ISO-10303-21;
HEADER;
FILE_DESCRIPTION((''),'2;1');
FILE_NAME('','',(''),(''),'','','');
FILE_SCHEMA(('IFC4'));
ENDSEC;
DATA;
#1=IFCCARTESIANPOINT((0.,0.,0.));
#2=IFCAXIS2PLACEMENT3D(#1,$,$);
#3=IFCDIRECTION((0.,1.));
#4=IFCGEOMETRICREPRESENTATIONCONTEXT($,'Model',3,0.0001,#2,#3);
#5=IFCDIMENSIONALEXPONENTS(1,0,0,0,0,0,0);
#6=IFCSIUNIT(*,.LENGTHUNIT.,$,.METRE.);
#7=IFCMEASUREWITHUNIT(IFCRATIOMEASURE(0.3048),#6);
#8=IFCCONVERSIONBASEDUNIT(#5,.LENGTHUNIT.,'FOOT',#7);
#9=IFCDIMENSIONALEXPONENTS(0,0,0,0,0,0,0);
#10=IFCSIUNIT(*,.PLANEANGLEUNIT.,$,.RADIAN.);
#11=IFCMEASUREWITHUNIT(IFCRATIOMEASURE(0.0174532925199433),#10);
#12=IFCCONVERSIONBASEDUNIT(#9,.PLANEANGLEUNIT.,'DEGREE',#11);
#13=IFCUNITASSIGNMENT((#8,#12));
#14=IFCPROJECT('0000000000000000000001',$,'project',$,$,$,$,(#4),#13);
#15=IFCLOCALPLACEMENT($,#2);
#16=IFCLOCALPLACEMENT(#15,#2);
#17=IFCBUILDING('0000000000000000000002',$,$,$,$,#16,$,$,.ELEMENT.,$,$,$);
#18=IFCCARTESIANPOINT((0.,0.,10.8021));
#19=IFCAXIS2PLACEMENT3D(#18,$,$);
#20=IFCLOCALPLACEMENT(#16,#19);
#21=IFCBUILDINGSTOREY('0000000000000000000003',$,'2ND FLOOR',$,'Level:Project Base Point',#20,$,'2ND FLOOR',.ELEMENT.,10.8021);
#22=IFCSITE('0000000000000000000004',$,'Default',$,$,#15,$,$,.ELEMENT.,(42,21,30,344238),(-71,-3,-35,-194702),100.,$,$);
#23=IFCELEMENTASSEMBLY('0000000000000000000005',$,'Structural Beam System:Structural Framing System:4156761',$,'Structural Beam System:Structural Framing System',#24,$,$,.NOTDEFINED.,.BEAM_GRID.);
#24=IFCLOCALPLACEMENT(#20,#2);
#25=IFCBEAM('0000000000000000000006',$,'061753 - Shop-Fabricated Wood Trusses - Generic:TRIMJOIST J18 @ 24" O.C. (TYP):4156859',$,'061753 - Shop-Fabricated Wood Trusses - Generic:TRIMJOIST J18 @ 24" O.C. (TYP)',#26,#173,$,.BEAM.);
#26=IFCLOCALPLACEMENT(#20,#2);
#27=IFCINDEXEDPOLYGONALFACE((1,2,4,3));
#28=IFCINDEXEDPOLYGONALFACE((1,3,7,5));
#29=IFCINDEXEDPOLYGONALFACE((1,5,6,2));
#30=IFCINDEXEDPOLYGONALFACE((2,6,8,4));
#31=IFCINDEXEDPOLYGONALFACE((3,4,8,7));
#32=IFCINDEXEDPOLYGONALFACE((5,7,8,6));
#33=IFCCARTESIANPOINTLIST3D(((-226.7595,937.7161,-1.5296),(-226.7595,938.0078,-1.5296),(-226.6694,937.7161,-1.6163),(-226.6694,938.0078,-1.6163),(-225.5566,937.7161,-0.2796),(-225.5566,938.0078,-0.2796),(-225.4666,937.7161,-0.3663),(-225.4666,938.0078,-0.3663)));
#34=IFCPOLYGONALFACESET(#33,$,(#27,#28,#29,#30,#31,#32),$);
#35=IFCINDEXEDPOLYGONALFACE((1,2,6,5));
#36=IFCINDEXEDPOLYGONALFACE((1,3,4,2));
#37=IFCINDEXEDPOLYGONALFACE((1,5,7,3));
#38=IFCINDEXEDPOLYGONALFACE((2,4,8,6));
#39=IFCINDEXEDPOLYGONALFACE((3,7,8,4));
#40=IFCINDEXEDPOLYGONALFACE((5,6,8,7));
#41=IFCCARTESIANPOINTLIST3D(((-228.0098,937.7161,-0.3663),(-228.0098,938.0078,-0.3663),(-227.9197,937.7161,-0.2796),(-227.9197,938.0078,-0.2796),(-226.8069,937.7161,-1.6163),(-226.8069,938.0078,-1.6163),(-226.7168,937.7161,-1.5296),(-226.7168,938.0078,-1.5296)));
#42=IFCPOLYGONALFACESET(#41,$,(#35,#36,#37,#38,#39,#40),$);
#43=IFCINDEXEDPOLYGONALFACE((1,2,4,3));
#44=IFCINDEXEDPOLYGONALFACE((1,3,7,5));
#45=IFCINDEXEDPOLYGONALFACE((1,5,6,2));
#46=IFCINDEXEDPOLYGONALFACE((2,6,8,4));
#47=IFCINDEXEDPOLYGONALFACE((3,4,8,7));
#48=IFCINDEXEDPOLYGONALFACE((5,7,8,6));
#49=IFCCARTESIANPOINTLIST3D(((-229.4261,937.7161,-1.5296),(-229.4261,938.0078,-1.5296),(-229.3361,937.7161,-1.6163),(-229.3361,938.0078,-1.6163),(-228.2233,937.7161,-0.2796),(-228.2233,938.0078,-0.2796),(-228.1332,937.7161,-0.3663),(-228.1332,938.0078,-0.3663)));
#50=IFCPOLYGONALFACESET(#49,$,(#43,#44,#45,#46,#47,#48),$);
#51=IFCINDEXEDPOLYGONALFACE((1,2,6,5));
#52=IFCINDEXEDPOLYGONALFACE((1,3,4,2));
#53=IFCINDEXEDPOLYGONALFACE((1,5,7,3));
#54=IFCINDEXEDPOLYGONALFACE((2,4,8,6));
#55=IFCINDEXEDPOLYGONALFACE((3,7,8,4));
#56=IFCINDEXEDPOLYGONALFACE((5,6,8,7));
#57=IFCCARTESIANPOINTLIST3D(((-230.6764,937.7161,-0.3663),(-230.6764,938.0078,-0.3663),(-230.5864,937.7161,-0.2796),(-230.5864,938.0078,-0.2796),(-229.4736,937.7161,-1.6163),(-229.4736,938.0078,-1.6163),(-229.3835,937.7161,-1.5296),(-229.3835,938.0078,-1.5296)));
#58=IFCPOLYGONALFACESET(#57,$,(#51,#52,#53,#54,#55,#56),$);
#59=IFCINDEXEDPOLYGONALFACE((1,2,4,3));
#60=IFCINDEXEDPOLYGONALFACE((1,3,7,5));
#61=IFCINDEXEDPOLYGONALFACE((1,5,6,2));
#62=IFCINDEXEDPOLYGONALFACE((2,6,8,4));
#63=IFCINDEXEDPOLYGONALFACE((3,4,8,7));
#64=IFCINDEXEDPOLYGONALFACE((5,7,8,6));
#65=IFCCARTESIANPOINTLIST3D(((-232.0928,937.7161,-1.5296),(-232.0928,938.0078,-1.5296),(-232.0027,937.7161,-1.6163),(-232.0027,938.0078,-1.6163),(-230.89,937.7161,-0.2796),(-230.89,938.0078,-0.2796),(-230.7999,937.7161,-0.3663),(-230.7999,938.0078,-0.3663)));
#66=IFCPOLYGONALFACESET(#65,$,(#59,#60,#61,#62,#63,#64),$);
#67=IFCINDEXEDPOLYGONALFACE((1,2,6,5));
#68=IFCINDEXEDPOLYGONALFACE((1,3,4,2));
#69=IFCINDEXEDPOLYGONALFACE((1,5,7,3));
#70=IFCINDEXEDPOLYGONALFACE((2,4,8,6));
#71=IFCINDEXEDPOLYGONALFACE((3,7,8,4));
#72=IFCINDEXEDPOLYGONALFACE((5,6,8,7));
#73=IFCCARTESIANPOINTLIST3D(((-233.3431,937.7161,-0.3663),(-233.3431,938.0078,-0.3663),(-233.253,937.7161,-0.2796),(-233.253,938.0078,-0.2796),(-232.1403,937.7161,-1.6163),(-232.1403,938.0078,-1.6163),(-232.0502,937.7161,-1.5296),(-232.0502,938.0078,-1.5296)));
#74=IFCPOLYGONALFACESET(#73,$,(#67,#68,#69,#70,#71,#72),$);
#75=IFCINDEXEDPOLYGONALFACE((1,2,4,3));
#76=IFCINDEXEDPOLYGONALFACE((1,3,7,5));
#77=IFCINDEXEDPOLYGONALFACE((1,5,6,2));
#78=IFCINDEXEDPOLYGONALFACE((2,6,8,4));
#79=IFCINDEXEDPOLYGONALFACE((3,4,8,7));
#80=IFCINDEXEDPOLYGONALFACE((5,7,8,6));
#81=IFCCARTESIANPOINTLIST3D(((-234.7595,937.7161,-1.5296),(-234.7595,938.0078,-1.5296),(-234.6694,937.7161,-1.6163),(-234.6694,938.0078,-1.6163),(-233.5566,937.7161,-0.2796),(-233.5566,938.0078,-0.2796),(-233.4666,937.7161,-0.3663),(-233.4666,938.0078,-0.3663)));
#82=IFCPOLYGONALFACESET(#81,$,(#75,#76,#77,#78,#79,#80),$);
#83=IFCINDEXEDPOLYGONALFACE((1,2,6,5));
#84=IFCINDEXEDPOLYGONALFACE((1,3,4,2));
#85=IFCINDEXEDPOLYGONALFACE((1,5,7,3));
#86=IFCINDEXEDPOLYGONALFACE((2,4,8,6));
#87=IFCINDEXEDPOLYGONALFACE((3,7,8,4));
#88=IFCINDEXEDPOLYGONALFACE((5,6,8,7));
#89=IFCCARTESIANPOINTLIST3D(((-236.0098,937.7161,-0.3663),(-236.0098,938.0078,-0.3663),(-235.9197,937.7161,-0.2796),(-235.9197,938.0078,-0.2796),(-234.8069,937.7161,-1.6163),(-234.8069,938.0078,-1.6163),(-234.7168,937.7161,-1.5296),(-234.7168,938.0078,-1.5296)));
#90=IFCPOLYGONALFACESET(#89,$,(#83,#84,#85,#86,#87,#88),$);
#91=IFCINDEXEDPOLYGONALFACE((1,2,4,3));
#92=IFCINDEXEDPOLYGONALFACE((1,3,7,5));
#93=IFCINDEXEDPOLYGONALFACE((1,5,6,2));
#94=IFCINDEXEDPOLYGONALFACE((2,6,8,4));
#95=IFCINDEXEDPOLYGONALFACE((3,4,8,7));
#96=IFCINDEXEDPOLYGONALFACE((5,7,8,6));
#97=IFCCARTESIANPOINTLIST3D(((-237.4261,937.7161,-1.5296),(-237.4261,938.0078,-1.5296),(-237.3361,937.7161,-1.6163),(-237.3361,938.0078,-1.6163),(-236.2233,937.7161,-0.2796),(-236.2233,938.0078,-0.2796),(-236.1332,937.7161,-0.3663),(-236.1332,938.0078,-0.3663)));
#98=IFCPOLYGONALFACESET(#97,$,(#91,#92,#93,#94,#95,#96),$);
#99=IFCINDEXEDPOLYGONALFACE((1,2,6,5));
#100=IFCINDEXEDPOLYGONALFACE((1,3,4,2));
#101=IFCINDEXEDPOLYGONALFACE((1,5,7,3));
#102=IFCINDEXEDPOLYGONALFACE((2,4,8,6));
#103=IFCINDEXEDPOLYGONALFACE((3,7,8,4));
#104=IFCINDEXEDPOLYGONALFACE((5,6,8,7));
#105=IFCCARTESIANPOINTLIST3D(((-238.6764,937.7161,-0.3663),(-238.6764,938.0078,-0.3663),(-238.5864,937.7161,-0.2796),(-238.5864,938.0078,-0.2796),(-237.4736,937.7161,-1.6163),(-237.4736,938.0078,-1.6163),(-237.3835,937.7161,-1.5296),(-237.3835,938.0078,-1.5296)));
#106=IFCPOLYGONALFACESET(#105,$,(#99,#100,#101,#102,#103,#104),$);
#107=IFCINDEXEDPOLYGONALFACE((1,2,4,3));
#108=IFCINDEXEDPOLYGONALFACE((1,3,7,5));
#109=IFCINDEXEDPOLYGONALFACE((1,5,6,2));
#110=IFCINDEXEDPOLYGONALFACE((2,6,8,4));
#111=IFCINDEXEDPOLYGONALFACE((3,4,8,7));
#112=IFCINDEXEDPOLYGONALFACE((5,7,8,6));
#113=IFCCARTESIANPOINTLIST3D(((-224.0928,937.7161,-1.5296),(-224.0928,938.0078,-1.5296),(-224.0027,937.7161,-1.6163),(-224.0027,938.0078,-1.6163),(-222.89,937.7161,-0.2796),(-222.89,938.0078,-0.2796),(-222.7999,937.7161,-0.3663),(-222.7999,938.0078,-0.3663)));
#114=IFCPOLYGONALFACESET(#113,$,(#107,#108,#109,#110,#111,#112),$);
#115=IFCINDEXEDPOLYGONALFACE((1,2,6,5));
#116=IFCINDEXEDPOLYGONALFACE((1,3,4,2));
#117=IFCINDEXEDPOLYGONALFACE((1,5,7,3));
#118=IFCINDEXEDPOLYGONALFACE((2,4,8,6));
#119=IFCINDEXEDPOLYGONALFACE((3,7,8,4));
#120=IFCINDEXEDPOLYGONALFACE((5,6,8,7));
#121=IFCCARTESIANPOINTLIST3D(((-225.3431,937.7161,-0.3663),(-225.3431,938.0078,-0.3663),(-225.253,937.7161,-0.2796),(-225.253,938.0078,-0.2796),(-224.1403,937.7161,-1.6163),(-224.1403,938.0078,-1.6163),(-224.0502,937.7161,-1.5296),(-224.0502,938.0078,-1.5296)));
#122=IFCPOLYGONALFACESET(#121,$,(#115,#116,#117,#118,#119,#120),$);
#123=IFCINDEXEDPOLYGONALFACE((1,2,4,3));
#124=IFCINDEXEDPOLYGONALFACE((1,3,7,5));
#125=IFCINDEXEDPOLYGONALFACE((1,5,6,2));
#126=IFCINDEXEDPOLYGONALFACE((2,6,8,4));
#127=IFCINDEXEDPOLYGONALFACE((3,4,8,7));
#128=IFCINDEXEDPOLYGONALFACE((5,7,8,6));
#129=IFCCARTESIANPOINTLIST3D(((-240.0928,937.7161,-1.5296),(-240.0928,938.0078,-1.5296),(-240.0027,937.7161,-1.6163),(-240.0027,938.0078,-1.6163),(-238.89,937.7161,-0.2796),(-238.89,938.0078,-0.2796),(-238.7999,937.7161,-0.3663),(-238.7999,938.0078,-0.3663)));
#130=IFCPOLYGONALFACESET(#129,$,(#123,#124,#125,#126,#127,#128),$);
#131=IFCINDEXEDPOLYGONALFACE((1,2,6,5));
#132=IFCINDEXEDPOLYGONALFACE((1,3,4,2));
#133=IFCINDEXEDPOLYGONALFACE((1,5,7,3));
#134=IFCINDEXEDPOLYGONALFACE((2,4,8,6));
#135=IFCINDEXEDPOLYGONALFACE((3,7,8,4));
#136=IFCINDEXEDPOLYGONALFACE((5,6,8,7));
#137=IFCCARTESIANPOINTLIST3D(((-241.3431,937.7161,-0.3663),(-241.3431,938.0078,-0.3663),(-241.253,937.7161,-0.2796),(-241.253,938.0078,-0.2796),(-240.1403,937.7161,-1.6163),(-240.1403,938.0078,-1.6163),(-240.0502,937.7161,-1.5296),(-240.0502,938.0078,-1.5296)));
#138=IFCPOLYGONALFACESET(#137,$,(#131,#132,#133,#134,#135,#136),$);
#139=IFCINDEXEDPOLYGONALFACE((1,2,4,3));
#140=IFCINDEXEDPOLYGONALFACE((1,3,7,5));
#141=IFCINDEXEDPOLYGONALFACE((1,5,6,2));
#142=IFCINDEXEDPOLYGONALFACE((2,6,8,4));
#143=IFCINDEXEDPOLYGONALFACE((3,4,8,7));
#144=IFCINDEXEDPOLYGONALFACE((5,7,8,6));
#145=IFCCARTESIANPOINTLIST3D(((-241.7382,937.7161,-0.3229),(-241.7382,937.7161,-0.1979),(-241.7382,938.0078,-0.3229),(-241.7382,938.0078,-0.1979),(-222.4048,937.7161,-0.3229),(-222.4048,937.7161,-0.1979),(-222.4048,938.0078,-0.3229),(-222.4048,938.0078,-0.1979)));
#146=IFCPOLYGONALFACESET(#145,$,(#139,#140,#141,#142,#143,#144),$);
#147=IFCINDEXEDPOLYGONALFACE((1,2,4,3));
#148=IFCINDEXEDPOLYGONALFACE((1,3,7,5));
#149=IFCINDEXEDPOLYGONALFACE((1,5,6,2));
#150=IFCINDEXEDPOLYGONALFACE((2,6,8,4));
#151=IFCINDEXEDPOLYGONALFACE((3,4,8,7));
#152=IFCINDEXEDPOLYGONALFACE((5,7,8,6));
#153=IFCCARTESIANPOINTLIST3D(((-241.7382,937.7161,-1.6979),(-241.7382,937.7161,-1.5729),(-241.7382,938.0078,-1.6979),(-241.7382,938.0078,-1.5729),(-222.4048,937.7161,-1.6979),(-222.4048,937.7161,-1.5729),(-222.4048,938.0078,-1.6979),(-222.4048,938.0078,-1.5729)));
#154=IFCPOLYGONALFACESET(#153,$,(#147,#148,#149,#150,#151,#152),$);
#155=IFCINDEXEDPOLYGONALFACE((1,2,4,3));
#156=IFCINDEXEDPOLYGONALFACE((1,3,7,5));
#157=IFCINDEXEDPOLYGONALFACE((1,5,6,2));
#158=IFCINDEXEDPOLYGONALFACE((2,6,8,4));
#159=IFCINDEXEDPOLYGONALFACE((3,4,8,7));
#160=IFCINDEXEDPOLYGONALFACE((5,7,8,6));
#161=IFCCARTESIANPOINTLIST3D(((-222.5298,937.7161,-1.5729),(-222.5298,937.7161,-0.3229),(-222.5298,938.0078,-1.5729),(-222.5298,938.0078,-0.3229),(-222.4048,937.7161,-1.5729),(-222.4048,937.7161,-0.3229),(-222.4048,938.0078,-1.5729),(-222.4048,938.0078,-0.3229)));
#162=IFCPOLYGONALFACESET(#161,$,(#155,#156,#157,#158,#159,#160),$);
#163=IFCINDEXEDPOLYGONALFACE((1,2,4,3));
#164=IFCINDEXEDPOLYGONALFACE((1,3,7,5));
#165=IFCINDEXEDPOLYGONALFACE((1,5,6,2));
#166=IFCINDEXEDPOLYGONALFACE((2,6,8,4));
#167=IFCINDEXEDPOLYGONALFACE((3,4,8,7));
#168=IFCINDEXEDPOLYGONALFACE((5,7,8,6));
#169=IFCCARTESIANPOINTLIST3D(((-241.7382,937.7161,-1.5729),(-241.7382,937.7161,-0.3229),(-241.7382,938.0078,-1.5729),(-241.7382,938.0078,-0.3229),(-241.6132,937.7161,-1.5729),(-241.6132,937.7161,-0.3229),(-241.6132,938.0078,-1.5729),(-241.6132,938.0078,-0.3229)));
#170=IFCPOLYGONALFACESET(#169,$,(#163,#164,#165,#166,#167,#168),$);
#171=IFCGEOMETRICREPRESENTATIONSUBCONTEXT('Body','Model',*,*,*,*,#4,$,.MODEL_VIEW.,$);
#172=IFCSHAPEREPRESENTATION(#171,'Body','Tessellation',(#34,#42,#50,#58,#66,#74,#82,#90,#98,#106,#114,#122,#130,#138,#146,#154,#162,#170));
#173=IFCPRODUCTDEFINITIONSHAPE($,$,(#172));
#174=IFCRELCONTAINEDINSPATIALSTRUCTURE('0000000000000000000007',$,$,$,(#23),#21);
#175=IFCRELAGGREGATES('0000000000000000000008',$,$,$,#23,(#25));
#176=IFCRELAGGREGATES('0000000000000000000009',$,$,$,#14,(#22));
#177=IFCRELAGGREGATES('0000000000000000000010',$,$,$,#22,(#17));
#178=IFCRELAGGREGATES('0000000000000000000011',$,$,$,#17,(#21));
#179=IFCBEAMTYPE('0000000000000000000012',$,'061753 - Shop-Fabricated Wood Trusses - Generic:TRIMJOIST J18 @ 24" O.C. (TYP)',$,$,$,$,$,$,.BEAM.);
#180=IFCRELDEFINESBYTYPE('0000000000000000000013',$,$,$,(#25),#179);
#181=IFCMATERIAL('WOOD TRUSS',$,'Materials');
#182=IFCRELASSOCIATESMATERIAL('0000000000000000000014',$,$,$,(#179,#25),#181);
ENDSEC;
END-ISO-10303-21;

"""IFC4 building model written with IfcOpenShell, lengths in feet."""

from ifc_helpers import new_model, entity, si_unit, converted_unit, direction, frame, frame_2d, origin, origin_2d_with_axis, place, context, subcontext, project, spatial, rectangle, extrude, source, transform, mapped, material, material_profile, profile_set, profile_usage, type_object, type_shapes, element, aggregate, save


model = new_model("IFC4")

# Units and contexts
model_context = context("Model", 3, precision=0.0001, world=origin(), true_north=direction((0.0, 1.0)))
body_context = subcontext(model_context, "Body", "Model", "MODEL_VIEW")
ifc_project = project(units=[converted_unit("LENGTHUNIT", "FOOT", entity("IfcRatioMeasure", 0.3048), si_unit("LENGTHUNIT", "METRE"), dimensions=[1, 0, 0, 0, 0, 0, 0]), converted_unit("PLANEANGLEUNIT", "DEGREE", entity("IfcRatioMeasure", 0.0174532925199433), si_unit("PLANEANGLEUNIT", "RADIAN"), dimensions=[0, 0, 0, 0, 0, 0, 0])], contexts=[model_context])

# Site, building, storey
site_placement = place(None, origin())
site = spatial("IfcSite", under=ifc_project, at=site_placement, Name="Default", CompositionType="ELEMENT", RefLatitude=(42, 21, 30, 344238), RefLongitude=(-71, -3, -35, -194702), RefElevation=100.0)
building_placement = place(site_placement, origin())
building = spatial("IfcBuilding", under=site, at=building_placement, CompositionType="ELEMENT")
storey_placement = place(building_placement, frame((0.0, 0.0, 10.8021)))
storey = spatial("IfcBuildingStorey", under=building, at=storey_placement, Name="2ND FLOOR", ObjectType="Level:Project Base Point", LongName="2ND FLOOR", CompositionType="ELEMENT", Elevation=10.8021)

# Element assembly, beam
ifc_material_1 = material(Name="WOOD TRUSS", Category="Materials")
ifc_material_profile_1 = material_profile(ifc_material_1, rectangle(XDim=1.7347, YDim=0.125, at=frame_2d((0.0, 0.0), x_axis=(1.0, 0.0))), Name="TRIMJOIST J18 @ 24\" O.C. (TYP)")
ifc_material_profile_2 = material_profile(ifc_material_1, rectangle(XDim=1.7347, YDim=0.125, at=frame_2d((0.0, 0.0), x_axis=(1.0, 0.0))), Name="TRIMJOIST J18 @ 24\" O.C. (TYP)")
ifc_material_profile_3 = material_profile(ifc_material_1, rectangle(XDim=1.7347, YDim=0.125, at=frame_2d((0.0, 0.0), x_axis=(1.0, 0.0))), Name="TRIMJOIST J18 @ 24\" O.C. (TYP)")
ifc_material_profile_4 = material_profile(ifc_material_1, rectangle(XDim=1.7347, YDim=0.125, at=frame_2d((0.0, 0.0), x_axis=(1.0, 0.0))), Name="TRIMJOIST J18 @ 24\" O.C. (TYP)")
ifc_material_profile_5 = material_profile(ifc_material_1, rectangle(XDim=1.7347, YDim=0.125, at=frame_2d((0.0, 0.0), x_axis=(1.0, 0.0))), Name="TRIMJOIST J18 @ 24\" O.C. (TYP)")
ifc_material_profile_6 = material_profile(ifc_material_1, rectangle(XDim=1.7347, YDim=0.125, at=frame_2d((0.0, 0.0), x_axis=(1.0, 0.0))), Name="TRIMJOIST J18 @ 24\" O.C. (TYP)")
ifc_material_profile_7 = material_profile(ifc_material_1, rectangle(XDim=1.7347, YDim=0.125, at=frame_2d((0.0, 0.0), x_axis=(1.0, 0.0))), Name="TRIMJOIST J18 @ 24\" O.C. (TYP)")
ifc_material_profile_8 = material_profile(ifc_material_1, rectangle(XDim=1.7347, YDim=0.125, at=frame_2d((0.0, 0.0), x_axis=(1.0, 0.0))), Name="TRIMJOIST J18 @ 24\" O.C. (TYP)")
ifc_material_profile_9 = material_profile(ifc_material_1, rectangle(XDim=1.7347, YDim=0.125, at=frame_2d((0.0, 0.0), x_axis=(1.0, 0.0))), Name="TRIMJOIST J18 @ 24\" O.C. (TYP)")
ifc_material_profile_10 = material_profile(ifc_material_1, rectangle(XDim=1.7347, YDim=0.125, at=origin_2d_with_axis()), Name="TRIMJOIST J18 @ 24\" O.C. (TYP)")
ifc_material_profile_11 = material_profile(ifc_material_1, rectangle(XDim=0.125, YDim=0.2917, at=origin_2d_with_axis()), Name="TRIMJOIST J18 @ 24\" O.C. (TYP)")
ifc_material_profile_12 = material_profile(ifc_material_1, rectangle(XDim=0.125, YDim=0.2917, at=origin_2d_with_axis()), Name="TRIMJOIST J18 @ 24\" O.C. (TYP)")
ifc_material_profile_13 = material_profile(ifc_material_1, rectangle(XDim=1.25, YDim=0.2917, at=origin_2d_with_axis()), Name="TRIMJOIST J18 @ 24\" O.C. (TYP)")
ifc_material_profile_14 = material_profile(ifc_material_1, rectangle(XDim=1.25, YDim=0.2917, at=origin_2d_with_axis()), Name="TRIMJOIST J18 @ 24\" O.C. (TYP)")
ifc_profile_set_1 = profile_set([ifc_material_profile_1, ifc_material_profile_2, ifc_material_profile_3, ifc_material_profile_4, ifc_material_profile_5, ifc_material_profile_6, ifc_material_profile_7, ifc_material_profile_8, ifc_material_profile_9, ifc_material_profile_10, ifc_material_profile_11, ifc_material_profile_12, ifc_material_profile_13, ifc_material_profile_14], Name="TRIMJOIST J18 @ 24\" O.C. (TYP)")
assembly_1_placement = place(storey_placement, origin())
assembly_1 = element("IfcElementAssembly", 1, at=assembly_1_placement, inside=storey, Name="Structural Beam System:Structural Framing System:4156761", ObjectType="Structural Beam System:Structural Framing System", AssemblyPlace="NOTDEFINED", PredefinedType="BEAM_GRID")
beam_type_1 = type_object("IfcBeamType", Name="061753 - Shop-Fabricated Wood Trusses - Generic:TRIMJOIST J18 @ 24\" O.C. (TYP)", PredefinedType="BEAM", material=ifc_profile_set_1)
shared_shape_1 = source(origin(), body_context, "Body", "SweptSolid", [
    extrude(rectangle(XDim=1.7347, YDim=0.125, at=frame_2d((0.0, 0.0), x_axis=(1.0, 0.0))), frame((5.9585, -0.1458, 0.0), z_axis=(0.0, 1.0, 0.0), x_axis=(0.693383, 0.0, 0.720569)), (0.0, 0.0, 1.0), 0.2917),
    extrude(rectangle(XDim=1.7347, YDim=0.125, at=origin_2d_with_axis()), frame((4.7082, -0.1458, 0.0), z_axis=(0.0, 1.0, 0.0), x_axis=(0.693383, 0.0, -0.720569)), (0.0, 0.0, 1.0), 0.2917),
    extrude(rectangle(XDim=1.7347, YDim=0.125, at=frame_2d((0.0, 0.0), x_axis=(1.0, 0.0))), frame((3.2918, -0.1458, 0.0), z_axis=(0.0, 1.0, 0.0), x_axis=(0.693383, 0.0, 0.720569)), (0.0, 0.0, 1.0), 0.2917),
    extrude(rectangle(XDim=1.7347, YDim=0.125, at=frame_2d((0.0, 0.0), x_axis=(1.0, 0.0))), frame((2.0415, -0.1458, 0.0), z_axis=(0.0, 1.0, 0.0), x_axis=(0.693383, 0.0, -0.720569)), (0.0, 0.0, 1.0), 0.2917),
    extrude(rectangle(XDim=1.7347, YDim=0.125, at=frame_2d((0.0, 0.0), x_axis=(1.0, 0.0))), frame((0.6251, -0.1458, 0.0), z_axis=(0.0, 1.0, 0.0), x_axis=(0.693383, 0.0, 0.720569)), (0.0, 0.0, 1.0), 0.2917),
    extrude(rectangle(XDim=1.7347, YDim=0.125, at=frame_2d((0.0, 0.0), x_axis=(1.0, 0.0))), frame((-0.6251, -0.1458, 0.0), z_axis=(0.0, 1.0, 0.0), x_axis=(0.693383, 0.0, -0.720569)), (0.0, 0.0, 1.0), 0.2917),
    extrude(rectangle(XDim=1.7347, YDim=0.125, at=frame_2d((0.0, 0.0), x_axis=(1.0, 0.0))), frame((-2.0415, -0.1458, 0.0), z_axis=(0.0, 1.0, 0.0), x_axis=(0.693383, 0.0, 0.720569)), (0.0, 0.0, 1.0), 0.2917),
    extrude(rectangle(XDim=1.7347, YDim=0.125, at=origin_2d_with_axis()), frame((-3.2918, -0.1458, 0.0), z_axis=(0.0, 1.0, 0.0), x_axis=(0.693383, 0.0, -0.720569)), (0.0, 0.0, 1.0), 0.2917),
    extrude(rectangle(XDim=1.7347, YDim=0.125, at=frame_2d((0.0, 0.0), x_axis=(1.0, 0.0))), frame((-4.7082, -0.1458, 0.0), z_axis=(0.0, 1.0, 0.0), x_axis=(0.693383, 0.0, 0.720569)), (0.0, 0.0, 1.0), 0.2917),
    extrude(rectangle(XDim=1.7347, YDim=0.125, at=frame_2d((0.0, 0.0), x_axis=(1.0, 0.0))), frame((-5.9585, -0.1458, 0.0), z_axis=(0.0, 1.0, 0.0), x_axis=(0.693383, 0.0, -0.720569)), (0.0, 0.0, 1.0), 0.2917),
    extrude(rectangle(XDim=1.7347, YDim=0.125, at=frame_2d((0.0, 0.0), x_axis=(1.0, 0.0))), frame((8.6251, -0.1458, 0.0), z_axis=(0.0, 1.0, 0.0), x_axis=(0.693383, 0.0, 0.720569)), (0.0, 0.0, 1.0), 0.2917),
    extrude(rectangle(XDim=1.7347, YDim=0.125, at=origin_2d_with_axis()), frame((7.3749, -0.1458, 0.0), z_axis=(0.0, 1.0, 0.0), x_axis=(0.693383, 0.0, -0.720569)), (0.0, 0.0, 1.0), 0.2917),
    extrude(rectangle(XDim=1.7347, YDim=0.125, at=frame_2d((0.0, 0.0), x_axis=(1.0, 0.0))), frame((-7.3749, -0.1458, 0.0), z_axis=(0.0, 1.0, 0.0), x_axis=(0.693383, 0.0, 0.720569)), (0.0, 0.0, 1.0), 0.2917),
    extrude(rectangle(XDim=1.7347, YDim=0.125, at=origin_2d_with_axis()), frame((-8.6251, -0.1458, 0.0), z_axis=(0.0, 1.0, 0.0), x_axis=(0.693383, 0.0, -0.720569)), (0.0, 0.0, 1.0), 0.2917),
    extrude(rectangle(XDim=0.125, YDim=0.2917, at=origin_2d_with_axis()), frame((-9.6667, 0.0, 0.6875), z_axis=(1.0, 0.0, 0.0), x_axis=(0.0, 0.0, -1.0)), (0.0, 0.0, 1.0), 19.3333),
    extrude(rectangle(XDim=0.125, YDim=0.2917, at=origin_2d_with_axis()), frame((-9.6667, 0.0, -0.6875), z_axis=(1.0, 0.0, 0.0), x_axis=(0.0, 0.0, -1.0)), (0.0, 0.0, 1.0), 19.3333),
    extrude(rectangle(XDim=1.25, YDim=0.2917, at=origin_2d_with_axis()), frame((9.5417, 0.0, 0.0), z_axis=(1.0, 0.0, 0.0), x_axis=(0.0, 0.0, -1.0)), (0.0, 0.0, 1.0), 0.125),
    extrude(rectangle(XDim=1.25, YDim=0.2917, at=origin_2d_with_axis()), frame((-9.6667, 0.0, 0.0), z_axis=(1.0, 0.0, 0.0), x_axis=(0.0, 0.0, -1.0)), (0.0, 0.0, 1.0), 0.125),
])
type_shapes(beam_type_1, [shared_shape_1])
ifc_profile_usage_1 = profile_usage(ifc_profile_set_1, cardinal=8)
beam_1_placement = place(assembly_1_placement, frame((-232.0715, 937.8619, -0.9479)))
beam_1 = element("IfcBeam", 2, at=beam_1_placement, type_object=beam_type_1, material=ifc_profile_usage_1, Name="061753 - Shop-Fabricated Wood Trusses - Generic:TRIMJOIST J18 @ 24\" O.C. (TYP):4156859", ObjectType="061753 - Shop-Fabricated Wood Trusses - Generic:TRIMJOIST J18 @ 24\" O.C. (TYP)", PredefinedType="BEAM", context=body_context, shape_type="MappedRepresentation", body=[
    mapped(shared_shape_1, transform((0.0, 0.0, 0.0), scale=1.0)),
])
aggregate(assembly_1, [beam_1])

save(model, "model.ifc")
